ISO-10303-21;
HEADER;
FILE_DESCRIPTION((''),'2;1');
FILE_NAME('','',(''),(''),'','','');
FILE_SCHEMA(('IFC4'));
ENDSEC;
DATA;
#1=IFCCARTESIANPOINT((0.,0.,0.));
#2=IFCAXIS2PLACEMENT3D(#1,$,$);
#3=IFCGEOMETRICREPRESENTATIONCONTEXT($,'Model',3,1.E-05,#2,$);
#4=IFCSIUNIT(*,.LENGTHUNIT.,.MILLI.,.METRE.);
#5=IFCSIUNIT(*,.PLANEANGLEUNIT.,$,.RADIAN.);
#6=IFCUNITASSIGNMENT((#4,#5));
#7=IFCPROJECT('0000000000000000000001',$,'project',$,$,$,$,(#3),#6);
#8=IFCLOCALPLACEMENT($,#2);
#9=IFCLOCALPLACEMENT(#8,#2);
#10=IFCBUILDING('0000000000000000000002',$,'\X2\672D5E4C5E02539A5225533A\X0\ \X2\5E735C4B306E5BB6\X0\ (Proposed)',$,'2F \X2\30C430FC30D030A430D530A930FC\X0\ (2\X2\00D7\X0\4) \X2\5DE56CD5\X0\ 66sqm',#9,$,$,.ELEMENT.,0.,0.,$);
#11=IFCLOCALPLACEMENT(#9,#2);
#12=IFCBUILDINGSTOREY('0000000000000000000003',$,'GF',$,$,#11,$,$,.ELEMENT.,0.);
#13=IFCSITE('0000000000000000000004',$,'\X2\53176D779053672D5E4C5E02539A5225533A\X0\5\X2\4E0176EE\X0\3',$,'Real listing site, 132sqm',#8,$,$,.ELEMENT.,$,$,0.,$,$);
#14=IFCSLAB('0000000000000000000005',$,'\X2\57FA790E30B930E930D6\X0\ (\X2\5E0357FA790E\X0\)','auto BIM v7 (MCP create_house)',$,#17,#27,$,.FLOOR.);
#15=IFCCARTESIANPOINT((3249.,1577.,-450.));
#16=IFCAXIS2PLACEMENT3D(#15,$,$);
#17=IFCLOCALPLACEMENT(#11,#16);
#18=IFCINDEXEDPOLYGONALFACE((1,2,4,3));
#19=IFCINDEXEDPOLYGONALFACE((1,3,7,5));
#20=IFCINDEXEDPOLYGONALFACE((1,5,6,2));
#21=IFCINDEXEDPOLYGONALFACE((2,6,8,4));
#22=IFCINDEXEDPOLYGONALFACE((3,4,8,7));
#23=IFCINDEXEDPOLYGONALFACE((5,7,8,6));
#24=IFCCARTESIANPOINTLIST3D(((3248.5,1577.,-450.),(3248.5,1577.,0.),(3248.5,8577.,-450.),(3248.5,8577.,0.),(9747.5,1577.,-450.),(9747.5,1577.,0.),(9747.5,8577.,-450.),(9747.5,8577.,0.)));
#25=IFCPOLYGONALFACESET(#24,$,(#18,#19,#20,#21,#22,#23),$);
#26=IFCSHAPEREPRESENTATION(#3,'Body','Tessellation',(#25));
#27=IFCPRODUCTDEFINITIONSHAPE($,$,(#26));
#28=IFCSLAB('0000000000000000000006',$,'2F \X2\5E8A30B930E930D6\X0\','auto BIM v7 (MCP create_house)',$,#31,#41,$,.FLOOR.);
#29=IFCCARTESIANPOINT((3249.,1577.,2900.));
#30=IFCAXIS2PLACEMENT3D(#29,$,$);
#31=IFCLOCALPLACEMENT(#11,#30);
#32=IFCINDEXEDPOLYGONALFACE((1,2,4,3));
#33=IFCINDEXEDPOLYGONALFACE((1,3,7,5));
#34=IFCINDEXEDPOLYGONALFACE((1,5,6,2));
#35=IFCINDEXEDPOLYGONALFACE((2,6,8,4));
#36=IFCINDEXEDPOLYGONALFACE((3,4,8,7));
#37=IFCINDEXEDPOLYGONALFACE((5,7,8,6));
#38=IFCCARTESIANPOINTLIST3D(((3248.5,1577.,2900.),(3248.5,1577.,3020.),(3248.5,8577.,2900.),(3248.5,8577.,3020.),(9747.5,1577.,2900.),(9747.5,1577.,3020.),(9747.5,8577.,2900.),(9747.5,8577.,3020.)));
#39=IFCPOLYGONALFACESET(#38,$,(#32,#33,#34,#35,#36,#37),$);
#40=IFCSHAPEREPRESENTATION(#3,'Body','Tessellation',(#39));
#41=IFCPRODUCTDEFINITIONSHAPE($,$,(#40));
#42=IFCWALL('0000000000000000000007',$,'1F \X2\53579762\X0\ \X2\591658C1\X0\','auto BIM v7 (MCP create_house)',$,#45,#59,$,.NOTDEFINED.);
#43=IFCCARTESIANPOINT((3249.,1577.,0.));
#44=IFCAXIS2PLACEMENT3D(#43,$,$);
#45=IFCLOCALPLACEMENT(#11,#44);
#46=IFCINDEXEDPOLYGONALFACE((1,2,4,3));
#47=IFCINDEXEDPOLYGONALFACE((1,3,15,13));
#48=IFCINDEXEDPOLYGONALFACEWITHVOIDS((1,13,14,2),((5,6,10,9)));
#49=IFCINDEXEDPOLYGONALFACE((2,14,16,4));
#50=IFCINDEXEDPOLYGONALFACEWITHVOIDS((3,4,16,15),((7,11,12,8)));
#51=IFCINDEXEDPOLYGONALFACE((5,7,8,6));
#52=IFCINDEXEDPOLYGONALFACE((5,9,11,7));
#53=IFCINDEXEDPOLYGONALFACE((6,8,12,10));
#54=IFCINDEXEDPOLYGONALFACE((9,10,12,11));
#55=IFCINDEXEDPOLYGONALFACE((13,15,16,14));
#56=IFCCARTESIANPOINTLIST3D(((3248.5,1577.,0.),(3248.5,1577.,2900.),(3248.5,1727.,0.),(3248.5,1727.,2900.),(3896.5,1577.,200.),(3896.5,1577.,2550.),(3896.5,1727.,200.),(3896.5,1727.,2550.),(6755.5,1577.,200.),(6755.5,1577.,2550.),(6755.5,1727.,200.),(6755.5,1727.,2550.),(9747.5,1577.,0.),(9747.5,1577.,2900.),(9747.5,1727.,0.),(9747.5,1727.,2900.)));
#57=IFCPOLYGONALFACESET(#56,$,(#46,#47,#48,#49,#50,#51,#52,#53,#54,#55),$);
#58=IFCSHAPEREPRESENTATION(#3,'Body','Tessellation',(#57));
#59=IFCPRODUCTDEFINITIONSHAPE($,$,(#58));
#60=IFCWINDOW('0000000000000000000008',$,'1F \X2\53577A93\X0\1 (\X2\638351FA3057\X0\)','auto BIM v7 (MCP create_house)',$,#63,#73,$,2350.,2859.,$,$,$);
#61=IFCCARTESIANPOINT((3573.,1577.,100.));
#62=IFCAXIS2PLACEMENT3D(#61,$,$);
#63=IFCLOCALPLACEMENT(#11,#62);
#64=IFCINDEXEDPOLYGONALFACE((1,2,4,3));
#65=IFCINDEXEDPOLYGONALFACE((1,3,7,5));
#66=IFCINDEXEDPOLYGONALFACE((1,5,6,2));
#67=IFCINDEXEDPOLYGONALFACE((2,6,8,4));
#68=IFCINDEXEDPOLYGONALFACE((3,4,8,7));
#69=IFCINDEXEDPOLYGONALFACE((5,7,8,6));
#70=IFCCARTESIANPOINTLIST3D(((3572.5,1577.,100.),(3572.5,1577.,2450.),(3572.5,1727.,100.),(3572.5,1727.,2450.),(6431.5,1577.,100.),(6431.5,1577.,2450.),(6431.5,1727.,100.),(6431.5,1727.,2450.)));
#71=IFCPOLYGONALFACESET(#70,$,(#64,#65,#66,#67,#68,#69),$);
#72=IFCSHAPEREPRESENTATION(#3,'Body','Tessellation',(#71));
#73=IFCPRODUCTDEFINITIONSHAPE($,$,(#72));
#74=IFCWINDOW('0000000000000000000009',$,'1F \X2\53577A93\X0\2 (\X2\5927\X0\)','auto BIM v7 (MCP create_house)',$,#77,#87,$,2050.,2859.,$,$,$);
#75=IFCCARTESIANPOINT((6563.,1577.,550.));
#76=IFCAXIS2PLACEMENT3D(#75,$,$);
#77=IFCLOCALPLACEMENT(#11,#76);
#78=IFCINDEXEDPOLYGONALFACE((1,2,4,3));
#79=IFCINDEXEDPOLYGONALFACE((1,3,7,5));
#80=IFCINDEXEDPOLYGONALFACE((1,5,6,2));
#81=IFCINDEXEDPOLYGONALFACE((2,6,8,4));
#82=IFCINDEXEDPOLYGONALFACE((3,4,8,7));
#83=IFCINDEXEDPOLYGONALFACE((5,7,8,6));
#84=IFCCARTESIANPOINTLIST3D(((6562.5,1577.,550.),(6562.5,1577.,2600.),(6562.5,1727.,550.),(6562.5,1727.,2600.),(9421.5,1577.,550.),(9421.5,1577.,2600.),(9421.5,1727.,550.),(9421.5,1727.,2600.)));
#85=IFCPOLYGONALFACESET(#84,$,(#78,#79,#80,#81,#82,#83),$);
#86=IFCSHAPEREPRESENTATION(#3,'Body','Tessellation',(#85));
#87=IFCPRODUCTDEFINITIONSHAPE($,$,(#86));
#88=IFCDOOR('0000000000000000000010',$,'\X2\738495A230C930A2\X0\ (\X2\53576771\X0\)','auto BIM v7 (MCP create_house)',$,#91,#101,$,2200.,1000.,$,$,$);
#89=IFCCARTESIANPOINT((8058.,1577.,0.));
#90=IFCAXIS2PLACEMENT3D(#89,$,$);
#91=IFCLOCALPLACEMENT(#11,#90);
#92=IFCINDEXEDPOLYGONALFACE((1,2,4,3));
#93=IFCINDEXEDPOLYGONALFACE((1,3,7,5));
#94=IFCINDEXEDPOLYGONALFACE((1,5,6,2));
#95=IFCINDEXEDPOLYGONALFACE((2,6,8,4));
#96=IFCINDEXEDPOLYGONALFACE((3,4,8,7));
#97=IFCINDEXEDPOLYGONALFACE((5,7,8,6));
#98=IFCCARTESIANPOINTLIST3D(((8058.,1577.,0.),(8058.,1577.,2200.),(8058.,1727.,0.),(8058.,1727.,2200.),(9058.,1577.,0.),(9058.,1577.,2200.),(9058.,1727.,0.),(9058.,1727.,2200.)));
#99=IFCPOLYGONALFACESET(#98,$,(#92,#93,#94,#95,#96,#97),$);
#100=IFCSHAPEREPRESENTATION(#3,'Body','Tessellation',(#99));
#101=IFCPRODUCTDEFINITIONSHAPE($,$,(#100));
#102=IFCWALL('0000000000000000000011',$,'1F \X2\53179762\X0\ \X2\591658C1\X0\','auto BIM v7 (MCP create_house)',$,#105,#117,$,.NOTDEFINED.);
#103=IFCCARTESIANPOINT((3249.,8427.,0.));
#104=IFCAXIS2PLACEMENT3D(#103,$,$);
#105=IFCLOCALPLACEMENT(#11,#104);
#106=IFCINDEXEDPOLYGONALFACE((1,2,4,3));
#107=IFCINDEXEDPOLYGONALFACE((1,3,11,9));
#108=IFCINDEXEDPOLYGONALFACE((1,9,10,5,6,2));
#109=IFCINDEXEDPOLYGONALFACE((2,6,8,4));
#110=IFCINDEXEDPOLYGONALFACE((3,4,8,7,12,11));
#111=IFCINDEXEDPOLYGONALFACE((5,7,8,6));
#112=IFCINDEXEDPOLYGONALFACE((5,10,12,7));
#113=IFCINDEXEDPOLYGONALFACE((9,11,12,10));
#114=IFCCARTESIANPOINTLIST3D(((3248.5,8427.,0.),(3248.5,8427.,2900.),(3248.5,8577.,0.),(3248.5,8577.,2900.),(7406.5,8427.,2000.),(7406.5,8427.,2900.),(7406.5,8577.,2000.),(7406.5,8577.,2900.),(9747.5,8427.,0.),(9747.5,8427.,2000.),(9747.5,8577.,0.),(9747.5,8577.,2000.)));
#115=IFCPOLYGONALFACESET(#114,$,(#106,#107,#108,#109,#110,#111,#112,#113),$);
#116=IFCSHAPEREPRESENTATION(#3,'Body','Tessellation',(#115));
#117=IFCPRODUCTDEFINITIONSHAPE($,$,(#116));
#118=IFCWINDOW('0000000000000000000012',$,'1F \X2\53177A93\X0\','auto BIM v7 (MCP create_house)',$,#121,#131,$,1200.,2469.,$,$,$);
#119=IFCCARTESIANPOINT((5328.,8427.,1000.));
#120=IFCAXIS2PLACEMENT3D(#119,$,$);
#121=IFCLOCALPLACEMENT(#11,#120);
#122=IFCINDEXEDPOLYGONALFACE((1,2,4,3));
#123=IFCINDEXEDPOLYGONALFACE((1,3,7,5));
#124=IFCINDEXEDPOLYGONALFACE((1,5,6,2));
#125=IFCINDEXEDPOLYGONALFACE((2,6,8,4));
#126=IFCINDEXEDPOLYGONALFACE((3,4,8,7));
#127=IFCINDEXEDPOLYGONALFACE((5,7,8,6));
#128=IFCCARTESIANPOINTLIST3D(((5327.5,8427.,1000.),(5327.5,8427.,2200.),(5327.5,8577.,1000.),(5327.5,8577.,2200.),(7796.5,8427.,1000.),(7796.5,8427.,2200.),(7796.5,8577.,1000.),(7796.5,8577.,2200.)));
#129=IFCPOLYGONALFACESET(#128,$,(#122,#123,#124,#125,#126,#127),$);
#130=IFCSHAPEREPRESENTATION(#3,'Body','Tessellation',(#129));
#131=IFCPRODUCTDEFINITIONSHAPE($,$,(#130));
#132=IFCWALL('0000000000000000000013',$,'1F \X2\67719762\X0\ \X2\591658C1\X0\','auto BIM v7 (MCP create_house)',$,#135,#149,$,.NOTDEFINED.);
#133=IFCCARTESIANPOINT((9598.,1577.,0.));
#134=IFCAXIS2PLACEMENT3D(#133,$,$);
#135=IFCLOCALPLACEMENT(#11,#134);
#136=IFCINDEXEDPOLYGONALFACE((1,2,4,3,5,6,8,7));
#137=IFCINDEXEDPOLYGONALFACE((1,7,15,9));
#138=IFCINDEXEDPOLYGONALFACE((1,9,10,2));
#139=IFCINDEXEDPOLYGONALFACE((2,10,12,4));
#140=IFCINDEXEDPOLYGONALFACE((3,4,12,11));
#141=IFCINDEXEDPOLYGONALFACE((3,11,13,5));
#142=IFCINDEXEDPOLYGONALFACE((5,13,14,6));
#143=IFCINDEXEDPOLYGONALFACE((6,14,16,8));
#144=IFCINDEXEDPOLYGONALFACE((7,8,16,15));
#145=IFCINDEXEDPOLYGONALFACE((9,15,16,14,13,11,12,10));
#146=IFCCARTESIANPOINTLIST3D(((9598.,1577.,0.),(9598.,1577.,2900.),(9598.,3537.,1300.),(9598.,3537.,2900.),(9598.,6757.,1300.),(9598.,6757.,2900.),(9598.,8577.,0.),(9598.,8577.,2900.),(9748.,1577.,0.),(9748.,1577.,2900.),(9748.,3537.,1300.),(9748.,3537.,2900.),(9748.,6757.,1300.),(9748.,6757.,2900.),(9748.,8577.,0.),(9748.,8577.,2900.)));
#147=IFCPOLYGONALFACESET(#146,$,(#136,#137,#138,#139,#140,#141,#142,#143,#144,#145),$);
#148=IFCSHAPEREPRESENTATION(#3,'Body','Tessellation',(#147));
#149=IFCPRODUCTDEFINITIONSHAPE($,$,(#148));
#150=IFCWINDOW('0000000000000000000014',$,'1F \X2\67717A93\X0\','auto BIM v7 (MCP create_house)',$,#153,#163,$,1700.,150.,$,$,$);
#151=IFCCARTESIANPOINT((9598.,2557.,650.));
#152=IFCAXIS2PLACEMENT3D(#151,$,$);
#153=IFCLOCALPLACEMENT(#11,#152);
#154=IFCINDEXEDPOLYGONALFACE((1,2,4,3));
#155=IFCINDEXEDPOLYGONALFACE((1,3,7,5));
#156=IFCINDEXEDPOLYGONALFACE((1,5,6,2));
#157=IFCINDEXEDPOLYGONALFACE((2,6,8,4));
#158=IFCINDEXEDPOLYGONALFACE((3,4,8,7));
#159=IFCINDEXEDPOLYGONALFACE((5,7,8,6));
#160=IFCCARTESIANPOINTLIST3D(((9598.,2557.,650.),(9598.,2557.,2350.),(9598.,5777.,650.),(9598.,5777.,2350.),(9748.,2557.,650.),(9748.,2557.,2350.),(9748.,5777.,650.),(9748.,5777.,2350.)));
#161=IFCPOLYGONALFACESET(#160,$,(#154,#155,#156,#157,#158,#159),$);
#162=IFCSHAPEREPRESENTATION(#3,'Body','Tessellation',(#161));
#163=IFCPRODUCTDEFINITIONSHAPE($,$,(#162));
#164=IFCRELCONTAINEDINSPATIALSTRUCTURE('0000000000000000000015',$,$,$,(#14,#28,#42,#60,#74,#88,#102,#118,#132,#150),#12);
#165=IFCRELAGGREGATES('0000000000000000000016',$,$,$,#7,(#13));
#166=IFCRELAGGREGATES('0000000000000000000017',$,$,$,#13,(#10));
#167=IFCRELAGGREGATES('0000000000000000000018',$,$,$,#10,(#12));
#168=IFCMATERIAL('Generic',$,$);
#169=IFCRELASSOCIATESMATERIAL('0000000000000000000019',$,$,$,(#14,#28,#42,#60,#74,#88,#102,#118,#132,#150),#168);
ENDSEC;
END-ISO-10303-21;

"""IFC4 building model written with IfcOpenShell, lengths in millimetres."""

from ifc_helpers import new_model, si_unit, frame, frame_2d, origin, place, context, project, spatial, rectangle, extrude, material, element, fill, save


model = new_model("IFC4")

# Units and contexts
model_context = context("Model", 3, precision=1e-05, world=origin())
ifc_project = project(units=[si_unit("LENGTHUNIT", "METRE", prefix="MILLI"), si_unit("PLANEANGLEUNIT", "RADIAN")], contexts=[model_context])

# Site, building, storey
site_placement = place(None, origin())
site = spatial("IfcSite", under=ifc_project, at=site_placement, Name="北海道札幌市厚別区5丁目3", ObjectType="Real listing site, 132sqm", CompositionType="ELEMENT", RefElevation=0.0)
building_placement = place(site_placement, origin())
building = spatial("IfcBuilding", under=site, at=building_placement, Name="札幌市厚別区 平屋の家 (Proposed)", ObjectType="2F ツーバイフォー (2×4) 工法 66sqm", CompositionType="ELEMENT", ElevationOfRefHeight=0.0, ElevationOfTerrain=0.0)
storey_placement = place(building_placement, origin())
storey = spatial("IfcBuildingStorey", under=building, at=storey_placement, Name="GF", CompositionType="ELEMENT", Elevation=0.0)

# Slabs
ifc_material = material(Name="Generic")
slab_1_placement = place(storey_placement, frame((3249.0, 1577.0, -450.0)))
element("IfcSlab", 1, at=slab_1_placement, inside=storey, material=ifc_material, Name="基礎スラブ (布基礎)", Description="auto BIM v7 (MCP create_house)", PredefinedType="FLOOR", context=model_context, shape_type="SweptSolid", body=[
    extrude(rectangle(XDim=6499.0, YDim=7000.0, at=frame_2d((3249.0, 3500.0))), frame((3249.0, 1577.0, -450.0)), (0.0, 0.0, 1.0), 450.0),
])
slab_2_placement = place(storey_placement, frame((3249.0, 1577.0, 2900.0)))
element("IfcSlab", 2, at=slab_2_placement, inside=storey, material=ifc_material, Name="2F 床スラブ", Description="auto BIM v7 (MCP create_house)", PredefinedType="FLOOR", context=model_context, shape_type="SweptSolid", body=[
    extrude(rectangle(XDim=6499.0, YDim=7000.0, at=frame_2d((3249.0, 3500.0))), frame((3249.0, 1577.0, 2900.0)), (0.0, 0.0, 1.0), 120.0),
])

# Wall, openings, windows, door
wall_1_placement = place(storey_placement, frame((3249.0, 1577.0, 0.0)))
wall_1 = element("IfcWall", 3, at=wall_1_placement, inside=storey, material=ifc_material, Name="1F 南面 外壁", Description="auto BIM v7 (MCP create_house)", PredefinedType="NOTDEFINED", context=model_context, shape_type="SweptSolid", body=[
    extrude(rectangle(XDim=6499.0, YDim=150.0, at=frame_2d((3249.0, 75.0))), frame((3249.0, 1577.0, 0.0)), (0.0, 0.0, 1.0), 2900.0),
])
opening_1_placement = place(storey_placement, frame((3573.0, 1577.0, 100.0)))
opening_1 = element("IfcOpeningElement", 4, at=opening_1_placement, cuts=wall_1, PredefinedType="NOTDEFINED", context=model_context, shape_type="SweptSolid", body=[
    extrude(rectangle(XDim=2859.0, YDim=150.0, at=frame_2d((1429.0, 75.0))), frame((3573.0, 1577.0, 100.0)), (0.0, 0.0, 1.0), 2350.0),
])
opening_2_placement = place(storey_placement, frame((6563.0, 1577.0, 550.0)))
opening_2 = element("IfcOpeningElement", 5, at=opening_2_placement, cuts=wall_1, PredefinedType="NOTDEFINED", context=model_context, shape_type="SweptSolid", body=[
    extrude(rectangle(XDim=2859.0, YDim=150.0, at=frame_2d((1429.0, 75.0))), frame((6563.0, 1577.0, 550.0)), (0.0, 0.0, 1.0), 2050.0),
])
opening_3_placement = place(storey_placement, frame((8058.0, 1577.0, 0.0)))
opening_3 = element("IfcOpeningElement", 6, at=opening_3_placement, cuts=wall_1, PredefinedType="NOTDEFINED", context=model_context, shape_type="SweptSolid", body=[
    extrude(rectangle(XDim=1000.0, YDim=150.0, at=frame_2d((500.0, 75.0))), frame((8058.0, 1577.0, 0.0)), (0.0, 0.0, 1.0), 2200.0),
])
window_1_placement = place(storey_placement, frame((3573.0, 1577.0, 100.0)))
window_1 = element("IfcWindow", 7, at=window_1_placement, inside=storey, material=ifc_material, Name="1F 南窓1 (掃出し)", Description="auto BIM v7 (MCP create_house)", OverallHeight=2350.0, OverallWidth=2859.0, context=model_context, shape_type="SweptSolid", body=[
    extrude(rectangle(XDim=2859.0, YDim=150.0, at=frame_2d((1429.0, 75.0))), frame((3573.0, 1577.0, 100.0)), (0.0, 0.0, 1.0), 2350.0),
])
fill(opening_1, window_1)
window_2_placement = place(storey_placement, frame((6563.0, 1577.0, 550.0)))
window_2 = element("IfcWindow", 8, at=window_2_placement, inside=storey, material=ifc_material, Name="1F 南窓2 (大)", Description="auto BIM v7 (MCP create_house)", OverallHeight=2050.0, OverallWidth=2859.0, context=model_context, shape_type="SweptSolid", body=[
    extrude(rectangle(XDim=2859.0, YDim=150.0, at=frame_2d((1429.0, 75.0))), frame((6563.0, 1577.0, 550.0)), (0.0, 0.0, 1.0), 2050.0),
])
fill(opening_2, window_2)
door_placement = place(storey_placement, frame((8058.0, 1577.0, 0.0)))
door = element("IfcDoor", 9, at=door_placement, inside=storey, material=ifc_material, Name="玄関ドア (南東)", Description="auto BIM v7 (MCP create_house)", OverallHeight=2200.0, OverallWidth=1000.0, context=model_context, shape_type="SweptSolid", body=[
    extrude(rectangle(XDim=1000.0, YDim=150.0, at=frame_2d((500.0, 75.0))), frame((8058.0, 1577.0, 0.0)), (0.0, 0.0, 1.0), 2200.0),
])
fill(opening_3, door)

# Walls, openings, windows
wall_2_placement = place(storey_placement, frame((3249.0, 8427.0, 0.0)))
wall_2 = element("IfcWall", 10, at=wall_2_placement, inside=storey, material=ifc_material, Name="1F 北面 外壁", Description="auto BIM v7 (MCP create_house)", PredefinedType="NOTDEFINED", context=model_context, shape_type="SweptSolid", body=[
    extrude(rectangle(XDim=6499.0, YDim=150.0, at=frame_2d((3249.0, 75.0))), frame((3249.0, 8427.0, 0.0)), (0.0, 0.0, 1.0), 2900.0),
])
opening_4_placement = place(storey_placement, frame((5328.0, 8427.0, 1000.0)))
opening_4 = element("IfcOpeningElement", 11, at=opening_4_placement, cuts=wall_2, PredefinedType="NOTDEFINED", context=model_context, shape_type="SweptSolid", body=[
    extrude(rectangle(XDim=2469.0, YDim=150.0, at=frame_2d((1234.0, 75.0))), frame((5328.0, 8427.0, 1000.0)), (0.0, 0.0, 1.0), 1200.0),
])
window_3_placement = place(storey_placement, frame((5328.0, 8427.0, 1000.0)))
window_3 = element("IfcWindow", 12, at=window_3_placement, inside=storey, material=ifc_material, Name="1F 北窓", Description="auto BIM v7 (MCP create_house)", OverallHeight=1200.0, OverallWidth=2469.0, context=model_context, shape_type="SweptSolid", body=[
    extrude(rectangle(XDim=2469.0, YDim=150.0, at=frame_2d((1234.0, 75.0))), frame((5328.0, 8427.0, 1000.0)), (0.0, 0.0, 1.0), 1200.0),
])
fill(opening_4, window_3)
wall_3_placement = place(storey_placement, frame((9598.0, 1577.0, 0.0)))
wall_3 = element("IfcWall", 13, at=wall_3_placement, inside=storey, material=ifc_material, Name="1F 東面 外壁", Description="auto BIM v7 (MCP create_house)", PredefinedType="NOTDEFINED", context=model_context, shape_type="SweptSolid", body=[
    extrude(rectangle(XDim=150.0, YDim=7000.0, at=frame_2d((75.0, 3500.0))), frame((9598.0, 1577.0, 0.0)), (0.0, 0.0, 1.0), 2900.0),
])
opening_5_placement = place(storey_placement, frame((9598.0, 2557.0, 650.0)))
opening_5 = element("IfcOpeningElement", 14, at=opening_5_placement, cuts=wall_3, PredefinedType="NOTDEFINED", context=model_context, shape_type="SweptSolid", body=[
    extrude(rectangle(XDim=150.0, YDim=3220.0, at=frame_2d((75.0, 1610.0))), frame((9598.0, 2557.0, 650.0)), (0.0, 0.0, 1.0), 1700.0),
])
window_4_placement = place(storey_placement, frame((9598.0, 2557.0, 650.0)))
window_4 = element("IfcWindow", 15, at=window_4_placement, inside=storey, material=ifc_material, Name="1F 東窓", Description="auto BIM v7 (MCP create_house)", OverallHeight=1700.0, OverallWidth=150.0, context=model_context, shape_type="SweptSolid", body=[
    extrude(rectangle(XDim=150.0, YDim=3220.0, at=frame_2d((75.0, 1610.0))), frame((9598.0, 2557.0, 650.0)), (0.0, 0.0, 1.0), 1700.0),
])
fill(opening_5, window_4)

save(model, "model.ifc")
